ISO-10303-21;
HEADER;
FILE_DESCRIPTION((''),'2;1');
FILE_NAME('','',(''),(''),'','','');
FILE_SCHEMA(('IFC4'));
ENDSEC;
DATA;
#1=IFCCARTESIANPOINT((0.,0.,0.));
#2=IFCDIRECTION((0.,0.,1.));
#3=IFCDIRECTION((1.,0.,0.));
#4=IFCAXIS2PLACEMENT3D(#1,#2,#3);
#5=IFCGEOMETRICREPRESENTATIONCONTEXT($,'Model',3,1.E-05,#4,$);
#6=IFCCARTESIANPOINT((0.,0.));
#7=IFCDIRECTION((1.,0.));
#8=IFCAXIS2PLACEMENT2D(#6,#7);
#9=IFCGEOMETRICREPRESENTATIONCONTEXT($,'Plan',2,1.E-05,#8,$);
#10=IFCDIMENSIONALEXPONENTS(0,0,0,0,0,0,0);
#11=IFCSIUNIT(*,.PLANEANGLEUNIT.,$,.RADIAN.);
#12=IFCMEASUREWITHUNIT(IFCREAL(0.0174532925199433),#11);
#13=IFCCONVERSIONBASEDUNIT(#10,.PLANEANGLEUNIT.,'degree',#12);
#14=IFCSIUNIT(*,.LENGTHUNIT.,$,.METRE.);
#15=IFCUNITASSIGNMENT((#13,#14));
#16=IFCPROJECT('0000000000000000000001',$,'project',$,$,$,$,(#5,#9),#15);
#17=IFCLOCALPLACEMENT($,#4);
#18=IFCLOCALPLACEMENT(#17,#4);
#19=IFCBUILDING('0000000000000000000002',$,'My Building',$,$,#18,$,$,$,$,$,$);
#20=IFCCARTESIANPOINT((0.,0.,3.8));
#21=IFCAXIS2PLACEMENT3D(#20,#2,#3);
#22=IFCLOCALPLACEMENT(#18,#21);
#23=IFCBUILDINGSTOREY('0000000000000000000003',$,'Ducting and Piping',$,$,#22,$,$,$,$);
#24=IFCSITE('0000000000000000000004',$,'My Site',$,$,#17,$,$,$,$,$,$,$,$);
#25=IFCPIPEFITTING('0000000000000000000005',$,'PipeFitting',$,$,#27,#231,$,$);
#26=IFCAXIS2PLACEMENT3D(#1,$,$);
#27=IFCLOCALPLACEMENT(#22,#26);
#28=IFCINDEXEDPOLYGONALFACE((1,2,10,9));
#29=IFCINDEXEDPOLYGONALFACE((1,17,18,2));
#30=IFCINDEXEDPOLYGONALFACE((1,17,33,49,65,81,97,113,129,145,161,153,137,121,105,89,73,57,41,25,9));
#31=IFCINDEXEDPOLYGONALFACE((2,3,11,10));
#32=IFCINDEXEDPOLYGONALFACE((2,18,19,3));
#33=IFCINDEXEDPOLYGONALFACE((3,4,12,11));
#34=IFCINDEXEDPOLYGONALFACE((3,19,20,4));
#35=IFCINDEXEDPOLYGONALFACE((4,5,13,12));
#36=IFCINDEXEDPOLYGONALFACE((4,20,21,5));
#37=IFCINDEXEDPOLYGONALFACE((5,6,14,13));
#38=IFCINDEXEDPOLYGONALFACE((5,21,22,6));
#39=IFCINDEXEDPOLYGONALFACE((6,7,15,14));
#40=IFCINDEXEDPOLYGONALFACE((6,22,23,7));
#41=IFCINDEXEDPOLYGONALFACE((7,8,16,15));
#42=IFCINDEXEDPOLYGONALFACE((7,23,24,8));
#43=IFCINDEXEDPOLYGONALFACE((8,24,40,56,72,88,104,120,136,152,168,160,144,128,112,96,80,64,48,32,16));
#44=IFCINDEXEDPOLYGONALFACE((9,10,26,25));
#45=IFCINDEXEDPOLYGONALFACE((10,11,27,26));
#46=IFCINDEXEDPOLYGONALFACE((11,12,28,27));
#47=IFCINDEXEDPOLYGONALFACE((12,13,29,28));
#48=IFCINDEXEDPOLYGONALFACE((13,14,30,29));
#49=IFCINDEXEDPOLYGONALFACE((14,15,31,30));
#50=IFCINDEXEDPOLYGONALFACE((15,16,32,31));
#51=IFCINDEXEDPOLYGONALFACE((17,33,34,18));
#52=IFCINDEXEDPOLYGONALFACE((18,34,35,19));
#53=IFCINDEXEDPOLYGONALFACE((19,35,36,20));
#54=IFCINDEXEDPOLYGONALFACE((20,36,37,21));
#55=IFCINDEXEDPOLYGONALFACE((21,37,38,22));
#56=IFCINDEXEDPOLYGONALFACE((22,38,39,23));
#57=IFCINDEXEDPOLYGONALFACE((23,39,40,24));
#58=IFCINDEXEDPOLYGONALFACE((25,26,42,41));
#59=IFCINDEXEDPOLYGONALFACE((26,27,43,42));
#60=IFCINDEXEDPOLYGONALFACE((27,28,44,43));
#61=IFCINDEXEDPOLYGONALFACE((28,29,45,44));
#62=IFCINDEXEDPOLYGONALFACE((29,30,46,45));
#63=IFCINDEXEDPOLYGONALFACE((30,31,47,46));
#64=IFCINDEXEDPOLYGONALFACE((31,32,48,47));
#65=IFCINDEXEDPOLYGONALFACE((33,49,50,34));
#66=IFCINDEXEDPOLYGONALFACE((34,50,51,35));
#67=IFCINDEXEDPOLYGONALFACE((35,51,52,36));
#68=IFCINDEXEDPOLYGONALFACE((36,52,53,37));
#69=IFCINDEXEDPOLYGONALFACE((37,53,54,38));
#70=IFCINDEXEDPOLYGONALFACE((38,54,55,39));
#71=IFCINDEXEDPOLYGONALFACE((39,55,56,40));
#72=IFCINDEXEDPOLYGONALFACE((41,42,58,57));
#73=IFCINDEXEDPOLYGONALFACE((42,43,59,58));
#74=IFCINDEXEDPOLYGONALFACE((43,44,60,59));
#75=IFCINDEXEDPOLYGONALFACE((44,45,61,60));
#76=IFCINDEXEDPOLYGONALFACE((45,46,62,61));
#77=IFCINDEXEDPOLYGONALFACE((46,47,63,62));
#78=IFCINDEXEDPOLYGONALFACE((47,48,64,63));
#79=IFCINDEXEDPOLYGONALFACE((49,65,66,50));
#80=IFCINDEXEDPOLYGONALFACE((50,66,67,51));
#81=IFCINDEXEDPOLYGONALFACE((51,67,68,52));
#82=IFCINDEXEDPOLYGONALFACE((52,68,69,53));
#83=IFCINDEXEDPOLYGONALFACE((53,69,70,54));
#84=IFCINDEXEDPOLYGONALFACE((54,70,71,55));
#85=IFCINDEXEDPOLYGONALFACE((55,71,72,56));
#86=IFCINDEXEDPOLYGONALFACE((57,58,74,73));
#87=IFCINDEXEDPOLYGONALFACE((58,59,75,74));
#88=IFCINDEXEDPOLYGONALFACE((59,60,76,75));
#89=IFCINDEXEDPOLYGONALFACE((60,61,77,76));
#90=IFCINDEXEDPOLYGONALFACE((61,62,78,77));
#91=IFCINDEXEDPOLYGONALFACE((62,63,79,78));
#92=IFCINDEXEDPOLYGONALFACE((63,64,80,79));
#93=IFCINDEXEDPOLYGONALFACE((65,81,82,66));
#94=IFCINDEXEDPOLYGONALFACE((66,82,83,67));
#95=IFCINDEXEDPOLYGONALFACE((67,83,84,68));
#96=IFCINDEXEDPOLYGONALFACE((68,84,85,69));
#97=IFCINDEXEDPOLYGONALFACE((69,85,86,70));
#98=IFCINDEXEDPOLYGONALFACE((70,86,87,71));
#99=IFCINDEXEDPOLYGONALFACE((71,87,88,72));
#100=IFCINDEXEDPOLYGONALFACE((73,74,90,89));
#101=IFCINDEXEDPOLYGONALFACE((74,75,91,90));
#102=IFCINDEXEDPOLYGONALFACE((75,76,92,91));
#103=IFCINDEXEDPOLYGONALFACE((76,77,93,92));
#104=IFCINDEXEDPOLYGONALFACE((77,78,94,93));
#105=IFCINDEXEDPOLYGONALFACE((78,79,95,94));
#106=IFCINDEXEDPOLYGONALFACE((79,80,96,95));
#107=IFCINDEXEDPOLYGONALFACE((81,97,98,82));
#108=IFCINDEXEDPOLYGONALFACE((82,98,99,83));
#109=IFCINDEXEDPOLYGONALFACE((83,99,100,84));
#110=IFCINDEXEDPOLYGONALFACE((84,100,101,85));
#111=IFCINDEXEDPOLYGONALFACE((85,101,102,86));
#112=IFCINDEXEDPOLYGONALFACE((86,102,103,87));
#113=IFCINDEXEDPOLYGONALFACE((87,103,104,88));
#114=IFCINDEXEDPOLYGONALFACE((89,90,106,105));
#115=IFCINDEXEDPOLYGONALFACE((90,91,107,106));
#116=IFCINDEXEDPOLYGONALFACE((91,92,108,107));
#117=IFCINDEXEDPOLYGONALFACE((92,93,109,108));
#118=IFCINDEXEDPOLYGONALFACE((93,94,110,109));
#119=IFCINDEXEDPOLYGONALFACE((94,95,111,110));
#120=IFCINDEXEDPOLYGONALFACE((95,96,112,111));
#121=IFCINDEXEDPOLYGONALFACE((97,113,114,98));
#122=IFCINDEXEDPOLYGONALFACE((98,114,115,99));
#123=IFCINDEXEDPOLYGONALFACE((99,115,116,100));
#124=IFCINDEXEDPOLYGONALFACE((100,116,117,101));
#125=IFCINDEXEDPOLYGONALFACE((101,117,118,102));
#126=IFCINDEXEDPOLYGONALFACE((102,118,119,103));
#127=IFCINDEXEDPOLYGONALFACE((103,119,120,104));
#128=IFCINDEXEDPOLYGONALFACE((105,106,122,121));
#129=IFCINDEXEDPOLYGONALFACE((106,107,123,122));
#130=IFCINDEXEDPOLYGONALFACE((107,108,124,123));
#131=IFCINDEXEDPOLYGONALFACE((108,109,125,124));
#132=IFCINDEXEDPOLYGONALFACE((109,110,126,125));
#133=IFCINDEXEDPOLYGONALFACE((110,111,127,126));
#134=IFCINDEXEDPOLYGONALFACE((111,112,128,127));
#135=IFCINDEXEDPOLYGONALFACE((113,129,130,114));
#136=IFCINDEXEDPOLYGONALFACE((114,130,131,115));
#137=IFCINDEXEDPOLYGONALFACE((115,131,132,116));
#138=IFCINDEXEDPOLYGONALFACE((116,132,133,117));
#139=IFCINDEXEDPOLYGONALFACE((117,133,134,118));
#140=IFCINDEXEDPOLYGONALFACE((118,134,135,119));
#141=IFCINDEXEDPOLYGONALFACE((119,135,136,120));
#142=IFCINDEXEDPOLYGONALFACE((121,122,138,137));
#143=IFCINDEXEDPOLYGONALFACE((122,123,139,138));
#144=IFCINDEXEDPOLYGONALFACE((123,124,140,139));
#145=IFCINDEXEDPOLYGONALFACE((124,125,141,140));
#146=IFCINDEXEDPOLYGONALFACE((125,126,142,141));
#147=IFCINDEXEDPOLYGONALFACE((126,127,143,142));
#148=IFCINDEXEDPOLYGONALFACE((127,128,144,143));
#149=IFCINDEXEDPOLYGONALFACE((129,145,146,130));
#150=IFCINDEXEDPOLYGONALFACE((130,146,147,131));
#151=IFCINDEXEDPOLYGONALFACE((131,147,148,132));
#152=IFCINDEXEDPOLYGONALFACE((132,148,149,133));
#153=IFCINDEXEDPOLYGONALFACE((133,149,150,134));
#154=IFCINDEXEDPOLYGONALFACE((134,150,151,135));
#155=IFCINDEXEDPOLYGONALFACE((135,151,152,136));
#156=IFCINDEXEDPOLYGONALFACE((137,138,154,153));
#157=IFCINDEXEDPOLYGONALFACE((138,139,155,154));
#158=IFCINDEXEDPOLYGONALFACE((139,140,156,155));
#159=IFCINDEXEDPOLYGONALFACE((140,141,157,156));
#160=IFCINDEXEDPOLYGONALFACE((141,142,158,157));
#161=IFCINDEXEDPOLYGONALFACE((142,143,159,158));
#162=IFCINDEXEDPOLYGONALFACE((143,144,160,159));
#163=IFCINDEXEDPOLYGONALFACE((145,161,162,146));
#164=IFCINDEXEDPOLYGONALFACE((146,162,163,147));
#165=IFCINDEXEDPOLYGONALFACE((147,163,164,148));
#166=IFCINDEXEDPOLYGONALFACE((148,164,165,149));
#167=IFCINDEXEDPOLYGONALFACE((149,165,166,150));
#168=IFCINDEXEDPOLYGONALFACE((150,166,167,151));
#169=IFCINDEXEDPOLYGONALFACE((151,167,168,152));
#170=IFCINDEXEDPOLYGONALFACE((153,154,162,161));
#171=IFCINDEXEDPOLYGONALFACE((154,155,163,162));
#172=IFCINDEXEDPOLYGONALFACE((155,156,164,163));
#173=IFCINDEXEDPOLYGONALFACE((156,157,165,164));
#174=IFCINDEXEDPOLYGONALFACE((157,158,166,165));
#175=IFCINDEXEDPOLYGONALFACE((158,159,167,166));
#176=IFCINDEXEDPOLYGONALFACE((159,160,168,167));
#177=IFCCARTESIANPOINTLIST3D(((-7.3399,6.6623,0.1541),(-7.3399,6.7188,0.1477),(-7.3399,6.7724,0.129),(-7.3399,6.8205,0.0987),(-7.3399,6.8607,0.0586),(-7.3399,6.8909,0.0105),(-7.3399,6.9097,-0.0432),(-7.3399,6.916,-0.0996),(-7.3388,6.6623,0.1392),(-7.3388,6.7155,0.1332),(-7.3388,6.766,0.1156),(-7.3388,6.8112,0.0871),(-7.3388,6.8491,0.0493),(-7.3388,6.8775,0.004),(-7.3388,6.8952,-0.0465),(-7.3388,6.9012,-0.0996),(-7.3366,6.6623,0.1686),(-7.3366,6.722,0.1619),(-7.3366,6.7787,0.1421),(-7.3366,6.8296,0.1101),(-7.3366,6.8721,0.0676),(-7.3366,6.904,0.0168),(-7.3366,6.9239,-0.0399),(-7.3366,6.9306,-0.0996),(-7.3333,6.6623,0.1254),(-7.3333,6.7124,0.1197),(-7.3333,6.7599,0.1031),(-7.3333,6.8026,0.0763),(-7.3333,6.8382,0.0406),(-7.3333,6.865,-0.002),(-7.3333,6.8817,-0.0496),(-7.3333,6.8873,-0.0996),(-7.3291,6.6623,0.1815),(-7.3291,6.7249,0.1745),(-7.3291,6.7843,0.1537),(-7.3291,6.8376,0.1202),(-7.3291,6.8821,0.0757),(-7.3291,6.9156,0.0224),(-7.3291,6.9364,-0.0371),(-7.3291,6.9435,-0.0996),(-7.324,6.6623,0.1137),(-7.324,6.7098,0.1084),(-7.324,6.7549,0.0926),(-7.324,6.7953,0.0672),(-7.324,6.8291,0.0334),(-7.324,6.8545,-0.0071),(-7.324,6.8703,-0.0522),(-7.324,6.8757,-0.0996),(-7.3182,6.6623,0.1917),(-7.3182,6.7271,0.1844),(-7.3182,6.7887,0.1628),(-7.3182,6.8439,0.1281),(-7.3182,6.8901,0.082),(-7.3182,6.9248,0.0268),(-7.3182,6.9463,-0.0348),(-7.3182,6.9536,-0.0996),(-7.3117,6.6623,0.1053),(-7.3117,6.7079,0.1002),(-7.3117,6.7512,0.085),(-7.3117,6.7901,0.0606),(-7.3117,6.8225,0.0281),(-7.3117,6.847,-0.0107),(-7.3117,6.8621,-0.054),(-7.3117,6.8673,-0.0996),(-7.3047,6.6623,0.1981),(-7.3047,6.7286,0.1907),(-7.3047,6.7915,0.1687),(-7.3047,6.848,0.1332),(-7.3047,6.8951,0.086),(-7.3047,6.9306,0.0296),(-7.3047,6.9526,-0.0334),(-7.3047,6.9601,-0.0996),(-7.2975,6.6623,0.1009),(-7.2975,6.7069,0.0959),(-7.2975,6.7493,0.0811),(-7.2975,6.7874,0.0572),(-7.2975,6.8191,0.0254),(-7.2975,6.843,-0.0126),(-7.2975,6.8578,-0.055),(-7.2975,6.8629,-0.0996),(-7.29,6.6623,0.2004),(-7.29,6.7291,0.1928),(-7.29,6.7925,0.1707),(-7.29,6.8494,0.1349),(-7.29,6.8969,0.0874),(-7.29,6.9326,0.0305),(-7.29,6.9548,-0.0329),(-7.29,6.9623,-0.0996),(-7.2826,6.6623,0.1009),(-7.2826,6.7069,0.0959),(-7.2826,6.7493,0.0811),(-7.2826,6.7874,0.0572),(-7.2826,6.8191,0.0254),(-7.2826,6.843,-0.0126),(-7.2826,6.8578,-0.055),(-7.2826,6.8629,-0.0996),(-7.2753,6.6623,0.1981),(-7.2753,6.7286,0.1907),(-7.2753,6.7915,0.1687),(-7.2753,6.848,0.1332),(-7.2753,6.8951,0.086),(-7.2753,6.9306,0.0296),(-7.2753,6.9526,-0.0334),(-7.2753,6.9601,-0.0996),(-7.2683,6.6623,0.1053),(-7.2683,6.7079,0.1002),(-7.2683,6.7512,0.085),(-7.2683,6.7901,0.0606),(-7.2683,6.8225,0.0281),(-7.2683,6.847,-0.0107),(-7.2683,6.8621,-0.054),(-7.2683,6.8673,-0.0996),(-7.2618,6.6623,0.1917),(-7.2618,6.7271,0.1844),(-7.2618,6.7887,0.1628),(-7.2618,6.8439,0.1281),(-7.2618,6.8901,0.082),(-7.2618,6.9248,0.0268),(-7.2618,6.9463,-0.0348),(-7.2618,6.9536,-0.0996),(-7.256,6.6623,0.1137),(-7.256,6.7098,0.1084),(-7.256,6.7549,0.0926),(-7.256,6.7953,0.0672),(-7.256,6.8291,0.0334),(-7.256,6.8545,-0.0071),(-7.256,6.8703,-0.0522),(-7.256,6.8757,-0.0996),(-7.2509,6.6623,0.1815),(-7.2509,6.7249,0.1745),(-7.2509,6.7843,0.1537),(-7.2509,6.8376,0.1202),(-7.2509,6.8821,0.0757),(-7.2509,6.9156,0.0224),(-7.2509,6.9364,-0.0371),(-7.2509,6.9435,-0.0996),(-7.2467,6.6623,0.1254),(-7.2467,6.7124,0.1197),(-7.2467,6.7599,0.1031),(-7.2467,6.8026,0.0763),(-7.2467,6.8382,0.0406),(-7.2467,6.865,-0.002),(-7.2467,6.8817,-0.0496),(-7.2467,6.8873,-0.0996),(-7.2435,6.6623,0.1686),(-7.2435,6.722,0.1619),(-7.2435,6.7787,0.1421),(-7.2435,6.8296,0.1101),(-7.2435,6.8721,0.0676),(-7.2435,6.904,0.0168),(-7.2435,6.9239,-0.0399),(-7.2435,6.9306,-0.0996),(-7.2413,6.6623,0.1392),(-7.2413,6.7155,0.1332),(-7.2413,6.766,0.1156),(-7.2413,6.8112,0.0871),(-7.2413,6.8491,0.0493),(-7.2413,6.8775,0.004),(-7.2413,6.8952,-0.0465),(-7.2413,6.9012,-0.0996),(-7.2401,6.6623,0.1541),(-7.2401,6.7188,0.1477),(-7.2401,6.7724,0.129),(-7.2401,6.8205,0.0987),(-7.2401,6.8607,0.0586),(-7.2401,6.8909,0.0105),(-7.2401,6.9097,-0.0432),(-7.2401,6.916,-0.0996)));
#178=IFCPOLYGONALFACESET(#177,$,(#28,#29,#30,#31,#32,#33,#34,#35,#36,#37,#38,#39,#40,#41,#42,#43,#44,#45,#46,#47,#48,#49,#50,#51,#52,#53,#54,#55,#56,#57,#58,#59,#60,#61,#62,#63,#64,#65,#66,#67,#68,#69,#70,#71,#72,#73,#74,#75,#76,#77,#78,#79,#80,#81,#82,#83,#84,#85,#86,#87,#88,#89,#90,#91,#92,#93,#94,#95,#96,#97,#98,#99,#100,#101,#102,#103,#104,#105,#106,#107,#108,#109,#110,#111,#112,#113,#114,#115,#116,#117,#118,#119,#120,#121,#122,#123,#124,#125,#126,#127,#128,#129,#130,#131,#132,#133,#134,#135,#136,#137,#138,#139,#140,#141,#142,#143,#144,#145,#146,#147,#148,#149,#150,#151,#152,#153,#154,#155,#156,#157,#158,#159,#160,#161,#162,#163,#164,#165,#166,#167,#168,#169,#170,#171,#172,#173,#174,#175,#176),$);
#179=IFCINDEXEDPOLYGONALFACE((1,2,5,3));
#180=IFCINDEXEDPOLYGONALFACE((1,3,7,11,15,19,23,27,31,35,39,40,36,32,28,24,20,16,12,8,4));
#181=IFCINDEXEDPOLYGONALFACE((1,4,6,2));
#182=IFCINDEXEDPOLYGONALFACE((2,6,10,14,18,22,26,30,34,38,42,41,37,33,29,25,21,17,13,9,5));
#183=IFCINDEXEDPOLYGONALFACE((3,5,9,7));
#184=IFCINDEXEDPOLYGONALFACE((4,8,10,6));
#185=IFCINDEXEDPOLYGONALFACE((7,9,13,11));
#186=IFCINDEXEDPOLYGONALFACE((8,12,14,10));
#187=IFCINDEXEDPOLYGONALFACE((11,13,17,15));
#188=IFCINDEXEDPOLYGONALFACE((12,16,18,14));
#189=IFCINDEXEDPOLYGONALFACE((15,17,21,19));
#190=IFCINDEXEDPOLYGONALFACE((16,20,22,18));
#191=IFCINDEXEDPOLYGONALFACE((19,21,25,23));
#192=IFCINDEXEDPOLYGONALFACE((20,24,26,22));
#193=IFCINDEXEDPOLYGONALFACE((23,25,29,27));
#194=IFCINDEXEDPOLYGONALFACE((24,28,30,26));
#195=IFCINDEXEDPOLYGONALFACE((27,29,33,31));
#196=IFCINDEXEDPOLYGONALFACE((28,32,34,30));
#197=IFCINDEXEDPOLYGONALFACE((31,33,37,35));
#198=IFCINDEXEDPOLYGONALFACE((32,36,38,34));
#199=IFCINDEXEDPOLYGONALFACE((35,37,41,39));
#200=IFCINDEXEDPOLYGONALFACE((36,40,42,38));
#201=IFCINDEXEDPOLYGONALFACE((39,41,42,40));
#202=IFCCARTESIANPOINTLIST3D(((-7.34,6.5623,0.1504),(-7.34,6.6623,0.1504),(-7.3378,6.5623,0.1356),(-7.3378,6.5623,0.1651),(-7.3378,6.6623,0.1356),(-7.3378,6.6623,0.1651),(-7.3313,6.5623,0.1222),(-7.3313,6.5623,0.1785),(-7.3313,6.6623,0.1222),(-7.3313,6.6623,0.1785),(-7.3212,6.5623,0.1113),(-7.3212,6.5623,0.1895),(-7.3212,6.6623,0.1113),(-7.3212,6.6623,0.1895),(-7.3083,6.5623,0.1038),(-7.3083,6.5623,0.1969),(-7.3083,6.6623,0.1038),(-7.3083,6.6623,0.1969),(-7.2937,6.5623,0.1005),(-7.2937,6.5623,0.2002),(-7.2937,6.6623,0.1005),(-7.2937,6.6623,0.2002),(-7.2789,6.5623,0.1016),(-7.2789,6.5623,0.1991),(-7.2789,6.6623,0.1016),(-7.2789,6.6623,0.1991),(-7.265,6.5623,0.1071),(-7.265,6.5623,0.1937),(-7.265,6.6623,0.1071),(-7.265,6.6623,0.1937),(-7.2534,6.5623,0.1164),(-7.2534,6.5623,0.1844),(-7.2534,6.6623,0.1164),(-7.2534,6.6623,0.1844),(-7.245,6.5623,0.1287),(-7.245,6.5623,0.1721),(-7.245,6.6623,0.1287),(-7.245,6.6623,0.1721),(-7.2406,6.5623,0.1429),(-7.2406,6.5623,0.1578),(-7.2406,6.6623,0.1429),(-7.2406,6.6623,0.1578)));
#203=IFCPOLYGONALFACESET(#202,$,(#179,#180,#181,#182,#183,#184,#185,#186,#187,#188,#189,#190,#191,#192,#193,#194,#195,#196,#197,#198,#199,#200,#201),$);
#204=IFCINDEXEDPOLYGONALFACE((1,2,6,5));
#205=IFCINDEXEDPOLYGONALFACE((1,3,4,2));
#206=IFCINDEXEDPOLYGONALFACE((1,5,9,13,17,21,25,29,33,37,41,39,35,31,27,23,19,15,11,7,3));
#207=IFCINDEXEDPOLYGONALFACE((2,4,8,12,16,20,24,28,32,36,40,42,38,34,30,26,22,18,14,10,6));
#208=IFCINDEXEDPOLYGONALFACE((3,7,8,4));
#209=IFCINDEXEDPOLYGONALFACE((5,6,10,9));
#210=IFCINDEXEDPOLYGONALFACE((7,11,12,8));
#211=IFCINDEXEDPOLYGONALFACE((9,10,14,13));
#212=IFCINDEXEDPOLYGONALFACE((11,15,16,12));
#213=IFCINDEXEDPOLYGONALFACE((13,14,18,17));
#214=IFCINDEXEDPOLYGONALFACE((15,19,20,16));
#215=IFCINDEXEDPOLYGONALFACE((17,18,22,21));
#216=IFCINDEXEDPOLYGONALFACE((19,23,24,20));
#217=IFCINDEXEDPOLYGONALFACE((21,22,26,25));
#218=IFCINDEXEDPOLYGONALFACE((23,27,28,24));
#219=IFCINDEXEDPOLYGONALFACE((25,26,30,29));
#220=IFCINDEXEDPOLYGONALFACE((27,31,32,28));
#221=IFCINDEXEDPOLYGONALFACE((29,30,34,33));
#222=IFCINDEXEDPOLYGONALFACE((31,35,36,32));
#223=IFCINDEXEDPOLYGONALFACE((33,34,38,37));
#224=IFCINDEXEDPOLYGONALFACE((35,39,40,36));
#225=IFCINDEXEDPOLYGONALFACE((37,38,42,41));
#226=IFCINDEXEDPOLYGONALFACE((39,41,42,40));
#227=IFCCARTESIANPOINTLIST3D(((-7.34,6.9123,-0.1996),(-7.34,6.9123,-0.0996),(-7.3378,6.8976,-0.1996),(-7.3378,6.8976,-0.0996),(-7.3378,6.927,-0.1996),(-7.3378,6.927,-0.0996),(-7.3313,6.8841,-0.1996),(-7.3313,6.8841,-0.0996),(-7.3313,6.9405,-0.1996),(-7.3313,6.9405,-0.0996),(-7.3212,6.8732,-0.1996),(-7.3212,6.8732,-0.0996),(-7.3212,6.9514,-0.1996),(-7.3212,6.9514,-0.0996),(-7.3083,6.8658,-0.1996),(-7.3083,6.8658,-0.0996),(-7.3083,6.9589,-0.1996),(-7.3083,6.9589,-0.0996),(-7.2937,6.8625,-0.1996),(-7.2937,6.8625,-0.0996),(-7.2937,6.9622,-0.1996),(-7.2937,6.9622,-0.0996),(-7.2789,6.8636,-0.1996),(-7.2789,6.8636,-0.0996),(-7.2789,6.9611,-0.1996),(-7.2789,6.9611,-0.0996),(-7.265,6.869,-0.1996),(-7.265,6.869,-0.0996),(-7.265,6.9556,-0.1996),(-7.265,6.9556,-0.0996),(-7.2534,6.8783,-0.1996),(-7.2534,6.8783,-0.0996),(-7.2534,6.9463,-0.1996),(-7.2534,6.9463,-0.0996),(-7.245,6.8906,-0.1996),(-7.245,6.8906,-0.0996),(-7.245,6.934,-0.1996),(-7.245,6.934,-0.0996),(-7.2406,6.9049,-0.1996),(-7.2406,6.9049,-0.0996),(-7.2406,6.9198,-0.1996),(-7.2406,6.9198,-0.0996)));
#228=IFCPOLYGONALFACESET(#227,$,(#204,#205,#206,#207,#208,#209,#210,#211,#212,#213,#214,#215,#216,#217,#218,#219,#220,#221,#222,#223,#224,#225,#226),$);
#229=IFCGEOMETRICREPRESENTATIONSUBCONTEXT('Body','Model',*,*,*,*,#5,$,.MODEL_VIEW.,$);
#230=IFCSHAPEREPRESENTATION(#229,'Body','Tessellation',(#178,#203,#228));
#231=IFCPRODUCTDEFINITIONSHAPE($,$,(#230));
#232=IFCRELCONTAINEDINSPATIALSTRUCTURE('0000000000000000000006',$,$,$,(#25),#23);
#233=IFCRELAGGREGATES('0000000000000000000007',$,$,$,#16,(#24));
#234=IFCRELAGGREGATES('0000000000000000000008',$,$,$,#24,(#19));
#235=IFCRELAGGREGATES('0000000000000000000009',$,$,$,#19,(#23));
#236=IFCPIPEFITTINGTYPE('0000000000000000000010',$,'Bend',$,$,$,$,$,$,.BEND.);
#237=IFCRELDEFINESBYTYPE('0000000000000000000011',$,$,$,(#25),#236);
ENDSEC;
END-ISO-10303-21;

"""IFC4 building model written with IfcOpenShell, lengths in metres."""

from ifc_helpers import new_model, entity, si_unit, converted_unit, frame, origin_with_axes, origin_2d_with_axis, place, context, subcontext, project, spatial, circle, extrude, source, transform, mapped, type_object, type_shapes, element, save


model = new_model("IFC4")

# Units and contexts
model_context = context("Model", 3, precision=1e-05, world=origin_with_axes())
plan_context = context("Plan", 2, precision=1e-05, world=origin_2d_with_axis())
body_context = subcontext(model_context, "Body", "Model", "MODEL_VIEW")
ifc_project = project(units=[converted_unit("PLANEANGLEUNIT", "degree", entity("IfcReal", 0.0174532925199433), si_unit("PLANEANGLEUNIT", "RADIAN"), dimensions=[0, 0, 0, 0, 0, 0, 0]), si_unit("LENGTHUNIT", "METRE")], contexts=[model_context, plan_context])

# Site, building, storey
site_placement = place(None, origin_with_axes())
site = spatial("IfcSite", under=ifc_project, at=site_placement, Name="My Site")
building_placement = place(site_placement, origin_with_axes())
building = spatial("IfcBuilding", under=site, at=building_placement, Name="My Building")
storey_placement = place(building_placement, frame((0.0, 0.0, 3.8), z_axis=(0.0, 0.0, 1.0), x_axis=(1.0, 0.0, 0.0)))
storey = spatial("IfcBuildingStorey", under=building, at=storey_placement, Name="Ducting and Piping")

# Pipe fitting
pipe_fitting_type = type_object("IfcPipeFittingType", Name="Bend", PredefinedType="BEND")
shared_shape = source(origin_with_axes(), body_context, "Body", "SolidModel", [
    entity("IfcSweptDiskSolid", entity("IfcIndexedPolyCurve", entity("IfcCartesianPointList3D", [[0.0, 0.0, 0.1], [0.0, -0.0732, 0.2768], [0.0, -0.25, 0.35]]), [entity("IfcArcIndex", [1, 2, 3])]), 0.05),
    extrude(circle(Radius=0.05), origin_with_axes(), (0.0, 0.0, 1.0), 0.1),
    extrude(circle(Radius=0.05), frame((0.0, -0.25, 0.35), z_axis=(0.0, -1.0, 0.0), x_axis=(1.0, 0.0, 0.0)), (0.0, 0.0, 1.0), 0.1),
])
type_shapes(pipe_fitting_type, [shared_shape])
for number, where, z_axis, x_axis, name in (
    (1, (-7.29, 6.5623, 0.1504), (0.0, 1.0, 0.0), (-1.0, 0.0, 0.0), "PipeFitting"),
):
    element("IfcPipeFitting", number, at=place(storey_placement, frame(where, z_axis=z_axis, x_axis=x_axis)), inside=storey, type_object=pipe_fitting_type, Name=name, context=body_context, shape_type="MappedRepresentation", body=[
        mapped(shared_shape, transform((0.0, 0.0, 0.0), x_axis=(1.0, 0.0, 0.0), y_axis=(0.0, 1.0, 0.0), z_axis=(0.0, 0.0, 1.0), scale=1.0)),
    ])

save(model, "model.ifc")
